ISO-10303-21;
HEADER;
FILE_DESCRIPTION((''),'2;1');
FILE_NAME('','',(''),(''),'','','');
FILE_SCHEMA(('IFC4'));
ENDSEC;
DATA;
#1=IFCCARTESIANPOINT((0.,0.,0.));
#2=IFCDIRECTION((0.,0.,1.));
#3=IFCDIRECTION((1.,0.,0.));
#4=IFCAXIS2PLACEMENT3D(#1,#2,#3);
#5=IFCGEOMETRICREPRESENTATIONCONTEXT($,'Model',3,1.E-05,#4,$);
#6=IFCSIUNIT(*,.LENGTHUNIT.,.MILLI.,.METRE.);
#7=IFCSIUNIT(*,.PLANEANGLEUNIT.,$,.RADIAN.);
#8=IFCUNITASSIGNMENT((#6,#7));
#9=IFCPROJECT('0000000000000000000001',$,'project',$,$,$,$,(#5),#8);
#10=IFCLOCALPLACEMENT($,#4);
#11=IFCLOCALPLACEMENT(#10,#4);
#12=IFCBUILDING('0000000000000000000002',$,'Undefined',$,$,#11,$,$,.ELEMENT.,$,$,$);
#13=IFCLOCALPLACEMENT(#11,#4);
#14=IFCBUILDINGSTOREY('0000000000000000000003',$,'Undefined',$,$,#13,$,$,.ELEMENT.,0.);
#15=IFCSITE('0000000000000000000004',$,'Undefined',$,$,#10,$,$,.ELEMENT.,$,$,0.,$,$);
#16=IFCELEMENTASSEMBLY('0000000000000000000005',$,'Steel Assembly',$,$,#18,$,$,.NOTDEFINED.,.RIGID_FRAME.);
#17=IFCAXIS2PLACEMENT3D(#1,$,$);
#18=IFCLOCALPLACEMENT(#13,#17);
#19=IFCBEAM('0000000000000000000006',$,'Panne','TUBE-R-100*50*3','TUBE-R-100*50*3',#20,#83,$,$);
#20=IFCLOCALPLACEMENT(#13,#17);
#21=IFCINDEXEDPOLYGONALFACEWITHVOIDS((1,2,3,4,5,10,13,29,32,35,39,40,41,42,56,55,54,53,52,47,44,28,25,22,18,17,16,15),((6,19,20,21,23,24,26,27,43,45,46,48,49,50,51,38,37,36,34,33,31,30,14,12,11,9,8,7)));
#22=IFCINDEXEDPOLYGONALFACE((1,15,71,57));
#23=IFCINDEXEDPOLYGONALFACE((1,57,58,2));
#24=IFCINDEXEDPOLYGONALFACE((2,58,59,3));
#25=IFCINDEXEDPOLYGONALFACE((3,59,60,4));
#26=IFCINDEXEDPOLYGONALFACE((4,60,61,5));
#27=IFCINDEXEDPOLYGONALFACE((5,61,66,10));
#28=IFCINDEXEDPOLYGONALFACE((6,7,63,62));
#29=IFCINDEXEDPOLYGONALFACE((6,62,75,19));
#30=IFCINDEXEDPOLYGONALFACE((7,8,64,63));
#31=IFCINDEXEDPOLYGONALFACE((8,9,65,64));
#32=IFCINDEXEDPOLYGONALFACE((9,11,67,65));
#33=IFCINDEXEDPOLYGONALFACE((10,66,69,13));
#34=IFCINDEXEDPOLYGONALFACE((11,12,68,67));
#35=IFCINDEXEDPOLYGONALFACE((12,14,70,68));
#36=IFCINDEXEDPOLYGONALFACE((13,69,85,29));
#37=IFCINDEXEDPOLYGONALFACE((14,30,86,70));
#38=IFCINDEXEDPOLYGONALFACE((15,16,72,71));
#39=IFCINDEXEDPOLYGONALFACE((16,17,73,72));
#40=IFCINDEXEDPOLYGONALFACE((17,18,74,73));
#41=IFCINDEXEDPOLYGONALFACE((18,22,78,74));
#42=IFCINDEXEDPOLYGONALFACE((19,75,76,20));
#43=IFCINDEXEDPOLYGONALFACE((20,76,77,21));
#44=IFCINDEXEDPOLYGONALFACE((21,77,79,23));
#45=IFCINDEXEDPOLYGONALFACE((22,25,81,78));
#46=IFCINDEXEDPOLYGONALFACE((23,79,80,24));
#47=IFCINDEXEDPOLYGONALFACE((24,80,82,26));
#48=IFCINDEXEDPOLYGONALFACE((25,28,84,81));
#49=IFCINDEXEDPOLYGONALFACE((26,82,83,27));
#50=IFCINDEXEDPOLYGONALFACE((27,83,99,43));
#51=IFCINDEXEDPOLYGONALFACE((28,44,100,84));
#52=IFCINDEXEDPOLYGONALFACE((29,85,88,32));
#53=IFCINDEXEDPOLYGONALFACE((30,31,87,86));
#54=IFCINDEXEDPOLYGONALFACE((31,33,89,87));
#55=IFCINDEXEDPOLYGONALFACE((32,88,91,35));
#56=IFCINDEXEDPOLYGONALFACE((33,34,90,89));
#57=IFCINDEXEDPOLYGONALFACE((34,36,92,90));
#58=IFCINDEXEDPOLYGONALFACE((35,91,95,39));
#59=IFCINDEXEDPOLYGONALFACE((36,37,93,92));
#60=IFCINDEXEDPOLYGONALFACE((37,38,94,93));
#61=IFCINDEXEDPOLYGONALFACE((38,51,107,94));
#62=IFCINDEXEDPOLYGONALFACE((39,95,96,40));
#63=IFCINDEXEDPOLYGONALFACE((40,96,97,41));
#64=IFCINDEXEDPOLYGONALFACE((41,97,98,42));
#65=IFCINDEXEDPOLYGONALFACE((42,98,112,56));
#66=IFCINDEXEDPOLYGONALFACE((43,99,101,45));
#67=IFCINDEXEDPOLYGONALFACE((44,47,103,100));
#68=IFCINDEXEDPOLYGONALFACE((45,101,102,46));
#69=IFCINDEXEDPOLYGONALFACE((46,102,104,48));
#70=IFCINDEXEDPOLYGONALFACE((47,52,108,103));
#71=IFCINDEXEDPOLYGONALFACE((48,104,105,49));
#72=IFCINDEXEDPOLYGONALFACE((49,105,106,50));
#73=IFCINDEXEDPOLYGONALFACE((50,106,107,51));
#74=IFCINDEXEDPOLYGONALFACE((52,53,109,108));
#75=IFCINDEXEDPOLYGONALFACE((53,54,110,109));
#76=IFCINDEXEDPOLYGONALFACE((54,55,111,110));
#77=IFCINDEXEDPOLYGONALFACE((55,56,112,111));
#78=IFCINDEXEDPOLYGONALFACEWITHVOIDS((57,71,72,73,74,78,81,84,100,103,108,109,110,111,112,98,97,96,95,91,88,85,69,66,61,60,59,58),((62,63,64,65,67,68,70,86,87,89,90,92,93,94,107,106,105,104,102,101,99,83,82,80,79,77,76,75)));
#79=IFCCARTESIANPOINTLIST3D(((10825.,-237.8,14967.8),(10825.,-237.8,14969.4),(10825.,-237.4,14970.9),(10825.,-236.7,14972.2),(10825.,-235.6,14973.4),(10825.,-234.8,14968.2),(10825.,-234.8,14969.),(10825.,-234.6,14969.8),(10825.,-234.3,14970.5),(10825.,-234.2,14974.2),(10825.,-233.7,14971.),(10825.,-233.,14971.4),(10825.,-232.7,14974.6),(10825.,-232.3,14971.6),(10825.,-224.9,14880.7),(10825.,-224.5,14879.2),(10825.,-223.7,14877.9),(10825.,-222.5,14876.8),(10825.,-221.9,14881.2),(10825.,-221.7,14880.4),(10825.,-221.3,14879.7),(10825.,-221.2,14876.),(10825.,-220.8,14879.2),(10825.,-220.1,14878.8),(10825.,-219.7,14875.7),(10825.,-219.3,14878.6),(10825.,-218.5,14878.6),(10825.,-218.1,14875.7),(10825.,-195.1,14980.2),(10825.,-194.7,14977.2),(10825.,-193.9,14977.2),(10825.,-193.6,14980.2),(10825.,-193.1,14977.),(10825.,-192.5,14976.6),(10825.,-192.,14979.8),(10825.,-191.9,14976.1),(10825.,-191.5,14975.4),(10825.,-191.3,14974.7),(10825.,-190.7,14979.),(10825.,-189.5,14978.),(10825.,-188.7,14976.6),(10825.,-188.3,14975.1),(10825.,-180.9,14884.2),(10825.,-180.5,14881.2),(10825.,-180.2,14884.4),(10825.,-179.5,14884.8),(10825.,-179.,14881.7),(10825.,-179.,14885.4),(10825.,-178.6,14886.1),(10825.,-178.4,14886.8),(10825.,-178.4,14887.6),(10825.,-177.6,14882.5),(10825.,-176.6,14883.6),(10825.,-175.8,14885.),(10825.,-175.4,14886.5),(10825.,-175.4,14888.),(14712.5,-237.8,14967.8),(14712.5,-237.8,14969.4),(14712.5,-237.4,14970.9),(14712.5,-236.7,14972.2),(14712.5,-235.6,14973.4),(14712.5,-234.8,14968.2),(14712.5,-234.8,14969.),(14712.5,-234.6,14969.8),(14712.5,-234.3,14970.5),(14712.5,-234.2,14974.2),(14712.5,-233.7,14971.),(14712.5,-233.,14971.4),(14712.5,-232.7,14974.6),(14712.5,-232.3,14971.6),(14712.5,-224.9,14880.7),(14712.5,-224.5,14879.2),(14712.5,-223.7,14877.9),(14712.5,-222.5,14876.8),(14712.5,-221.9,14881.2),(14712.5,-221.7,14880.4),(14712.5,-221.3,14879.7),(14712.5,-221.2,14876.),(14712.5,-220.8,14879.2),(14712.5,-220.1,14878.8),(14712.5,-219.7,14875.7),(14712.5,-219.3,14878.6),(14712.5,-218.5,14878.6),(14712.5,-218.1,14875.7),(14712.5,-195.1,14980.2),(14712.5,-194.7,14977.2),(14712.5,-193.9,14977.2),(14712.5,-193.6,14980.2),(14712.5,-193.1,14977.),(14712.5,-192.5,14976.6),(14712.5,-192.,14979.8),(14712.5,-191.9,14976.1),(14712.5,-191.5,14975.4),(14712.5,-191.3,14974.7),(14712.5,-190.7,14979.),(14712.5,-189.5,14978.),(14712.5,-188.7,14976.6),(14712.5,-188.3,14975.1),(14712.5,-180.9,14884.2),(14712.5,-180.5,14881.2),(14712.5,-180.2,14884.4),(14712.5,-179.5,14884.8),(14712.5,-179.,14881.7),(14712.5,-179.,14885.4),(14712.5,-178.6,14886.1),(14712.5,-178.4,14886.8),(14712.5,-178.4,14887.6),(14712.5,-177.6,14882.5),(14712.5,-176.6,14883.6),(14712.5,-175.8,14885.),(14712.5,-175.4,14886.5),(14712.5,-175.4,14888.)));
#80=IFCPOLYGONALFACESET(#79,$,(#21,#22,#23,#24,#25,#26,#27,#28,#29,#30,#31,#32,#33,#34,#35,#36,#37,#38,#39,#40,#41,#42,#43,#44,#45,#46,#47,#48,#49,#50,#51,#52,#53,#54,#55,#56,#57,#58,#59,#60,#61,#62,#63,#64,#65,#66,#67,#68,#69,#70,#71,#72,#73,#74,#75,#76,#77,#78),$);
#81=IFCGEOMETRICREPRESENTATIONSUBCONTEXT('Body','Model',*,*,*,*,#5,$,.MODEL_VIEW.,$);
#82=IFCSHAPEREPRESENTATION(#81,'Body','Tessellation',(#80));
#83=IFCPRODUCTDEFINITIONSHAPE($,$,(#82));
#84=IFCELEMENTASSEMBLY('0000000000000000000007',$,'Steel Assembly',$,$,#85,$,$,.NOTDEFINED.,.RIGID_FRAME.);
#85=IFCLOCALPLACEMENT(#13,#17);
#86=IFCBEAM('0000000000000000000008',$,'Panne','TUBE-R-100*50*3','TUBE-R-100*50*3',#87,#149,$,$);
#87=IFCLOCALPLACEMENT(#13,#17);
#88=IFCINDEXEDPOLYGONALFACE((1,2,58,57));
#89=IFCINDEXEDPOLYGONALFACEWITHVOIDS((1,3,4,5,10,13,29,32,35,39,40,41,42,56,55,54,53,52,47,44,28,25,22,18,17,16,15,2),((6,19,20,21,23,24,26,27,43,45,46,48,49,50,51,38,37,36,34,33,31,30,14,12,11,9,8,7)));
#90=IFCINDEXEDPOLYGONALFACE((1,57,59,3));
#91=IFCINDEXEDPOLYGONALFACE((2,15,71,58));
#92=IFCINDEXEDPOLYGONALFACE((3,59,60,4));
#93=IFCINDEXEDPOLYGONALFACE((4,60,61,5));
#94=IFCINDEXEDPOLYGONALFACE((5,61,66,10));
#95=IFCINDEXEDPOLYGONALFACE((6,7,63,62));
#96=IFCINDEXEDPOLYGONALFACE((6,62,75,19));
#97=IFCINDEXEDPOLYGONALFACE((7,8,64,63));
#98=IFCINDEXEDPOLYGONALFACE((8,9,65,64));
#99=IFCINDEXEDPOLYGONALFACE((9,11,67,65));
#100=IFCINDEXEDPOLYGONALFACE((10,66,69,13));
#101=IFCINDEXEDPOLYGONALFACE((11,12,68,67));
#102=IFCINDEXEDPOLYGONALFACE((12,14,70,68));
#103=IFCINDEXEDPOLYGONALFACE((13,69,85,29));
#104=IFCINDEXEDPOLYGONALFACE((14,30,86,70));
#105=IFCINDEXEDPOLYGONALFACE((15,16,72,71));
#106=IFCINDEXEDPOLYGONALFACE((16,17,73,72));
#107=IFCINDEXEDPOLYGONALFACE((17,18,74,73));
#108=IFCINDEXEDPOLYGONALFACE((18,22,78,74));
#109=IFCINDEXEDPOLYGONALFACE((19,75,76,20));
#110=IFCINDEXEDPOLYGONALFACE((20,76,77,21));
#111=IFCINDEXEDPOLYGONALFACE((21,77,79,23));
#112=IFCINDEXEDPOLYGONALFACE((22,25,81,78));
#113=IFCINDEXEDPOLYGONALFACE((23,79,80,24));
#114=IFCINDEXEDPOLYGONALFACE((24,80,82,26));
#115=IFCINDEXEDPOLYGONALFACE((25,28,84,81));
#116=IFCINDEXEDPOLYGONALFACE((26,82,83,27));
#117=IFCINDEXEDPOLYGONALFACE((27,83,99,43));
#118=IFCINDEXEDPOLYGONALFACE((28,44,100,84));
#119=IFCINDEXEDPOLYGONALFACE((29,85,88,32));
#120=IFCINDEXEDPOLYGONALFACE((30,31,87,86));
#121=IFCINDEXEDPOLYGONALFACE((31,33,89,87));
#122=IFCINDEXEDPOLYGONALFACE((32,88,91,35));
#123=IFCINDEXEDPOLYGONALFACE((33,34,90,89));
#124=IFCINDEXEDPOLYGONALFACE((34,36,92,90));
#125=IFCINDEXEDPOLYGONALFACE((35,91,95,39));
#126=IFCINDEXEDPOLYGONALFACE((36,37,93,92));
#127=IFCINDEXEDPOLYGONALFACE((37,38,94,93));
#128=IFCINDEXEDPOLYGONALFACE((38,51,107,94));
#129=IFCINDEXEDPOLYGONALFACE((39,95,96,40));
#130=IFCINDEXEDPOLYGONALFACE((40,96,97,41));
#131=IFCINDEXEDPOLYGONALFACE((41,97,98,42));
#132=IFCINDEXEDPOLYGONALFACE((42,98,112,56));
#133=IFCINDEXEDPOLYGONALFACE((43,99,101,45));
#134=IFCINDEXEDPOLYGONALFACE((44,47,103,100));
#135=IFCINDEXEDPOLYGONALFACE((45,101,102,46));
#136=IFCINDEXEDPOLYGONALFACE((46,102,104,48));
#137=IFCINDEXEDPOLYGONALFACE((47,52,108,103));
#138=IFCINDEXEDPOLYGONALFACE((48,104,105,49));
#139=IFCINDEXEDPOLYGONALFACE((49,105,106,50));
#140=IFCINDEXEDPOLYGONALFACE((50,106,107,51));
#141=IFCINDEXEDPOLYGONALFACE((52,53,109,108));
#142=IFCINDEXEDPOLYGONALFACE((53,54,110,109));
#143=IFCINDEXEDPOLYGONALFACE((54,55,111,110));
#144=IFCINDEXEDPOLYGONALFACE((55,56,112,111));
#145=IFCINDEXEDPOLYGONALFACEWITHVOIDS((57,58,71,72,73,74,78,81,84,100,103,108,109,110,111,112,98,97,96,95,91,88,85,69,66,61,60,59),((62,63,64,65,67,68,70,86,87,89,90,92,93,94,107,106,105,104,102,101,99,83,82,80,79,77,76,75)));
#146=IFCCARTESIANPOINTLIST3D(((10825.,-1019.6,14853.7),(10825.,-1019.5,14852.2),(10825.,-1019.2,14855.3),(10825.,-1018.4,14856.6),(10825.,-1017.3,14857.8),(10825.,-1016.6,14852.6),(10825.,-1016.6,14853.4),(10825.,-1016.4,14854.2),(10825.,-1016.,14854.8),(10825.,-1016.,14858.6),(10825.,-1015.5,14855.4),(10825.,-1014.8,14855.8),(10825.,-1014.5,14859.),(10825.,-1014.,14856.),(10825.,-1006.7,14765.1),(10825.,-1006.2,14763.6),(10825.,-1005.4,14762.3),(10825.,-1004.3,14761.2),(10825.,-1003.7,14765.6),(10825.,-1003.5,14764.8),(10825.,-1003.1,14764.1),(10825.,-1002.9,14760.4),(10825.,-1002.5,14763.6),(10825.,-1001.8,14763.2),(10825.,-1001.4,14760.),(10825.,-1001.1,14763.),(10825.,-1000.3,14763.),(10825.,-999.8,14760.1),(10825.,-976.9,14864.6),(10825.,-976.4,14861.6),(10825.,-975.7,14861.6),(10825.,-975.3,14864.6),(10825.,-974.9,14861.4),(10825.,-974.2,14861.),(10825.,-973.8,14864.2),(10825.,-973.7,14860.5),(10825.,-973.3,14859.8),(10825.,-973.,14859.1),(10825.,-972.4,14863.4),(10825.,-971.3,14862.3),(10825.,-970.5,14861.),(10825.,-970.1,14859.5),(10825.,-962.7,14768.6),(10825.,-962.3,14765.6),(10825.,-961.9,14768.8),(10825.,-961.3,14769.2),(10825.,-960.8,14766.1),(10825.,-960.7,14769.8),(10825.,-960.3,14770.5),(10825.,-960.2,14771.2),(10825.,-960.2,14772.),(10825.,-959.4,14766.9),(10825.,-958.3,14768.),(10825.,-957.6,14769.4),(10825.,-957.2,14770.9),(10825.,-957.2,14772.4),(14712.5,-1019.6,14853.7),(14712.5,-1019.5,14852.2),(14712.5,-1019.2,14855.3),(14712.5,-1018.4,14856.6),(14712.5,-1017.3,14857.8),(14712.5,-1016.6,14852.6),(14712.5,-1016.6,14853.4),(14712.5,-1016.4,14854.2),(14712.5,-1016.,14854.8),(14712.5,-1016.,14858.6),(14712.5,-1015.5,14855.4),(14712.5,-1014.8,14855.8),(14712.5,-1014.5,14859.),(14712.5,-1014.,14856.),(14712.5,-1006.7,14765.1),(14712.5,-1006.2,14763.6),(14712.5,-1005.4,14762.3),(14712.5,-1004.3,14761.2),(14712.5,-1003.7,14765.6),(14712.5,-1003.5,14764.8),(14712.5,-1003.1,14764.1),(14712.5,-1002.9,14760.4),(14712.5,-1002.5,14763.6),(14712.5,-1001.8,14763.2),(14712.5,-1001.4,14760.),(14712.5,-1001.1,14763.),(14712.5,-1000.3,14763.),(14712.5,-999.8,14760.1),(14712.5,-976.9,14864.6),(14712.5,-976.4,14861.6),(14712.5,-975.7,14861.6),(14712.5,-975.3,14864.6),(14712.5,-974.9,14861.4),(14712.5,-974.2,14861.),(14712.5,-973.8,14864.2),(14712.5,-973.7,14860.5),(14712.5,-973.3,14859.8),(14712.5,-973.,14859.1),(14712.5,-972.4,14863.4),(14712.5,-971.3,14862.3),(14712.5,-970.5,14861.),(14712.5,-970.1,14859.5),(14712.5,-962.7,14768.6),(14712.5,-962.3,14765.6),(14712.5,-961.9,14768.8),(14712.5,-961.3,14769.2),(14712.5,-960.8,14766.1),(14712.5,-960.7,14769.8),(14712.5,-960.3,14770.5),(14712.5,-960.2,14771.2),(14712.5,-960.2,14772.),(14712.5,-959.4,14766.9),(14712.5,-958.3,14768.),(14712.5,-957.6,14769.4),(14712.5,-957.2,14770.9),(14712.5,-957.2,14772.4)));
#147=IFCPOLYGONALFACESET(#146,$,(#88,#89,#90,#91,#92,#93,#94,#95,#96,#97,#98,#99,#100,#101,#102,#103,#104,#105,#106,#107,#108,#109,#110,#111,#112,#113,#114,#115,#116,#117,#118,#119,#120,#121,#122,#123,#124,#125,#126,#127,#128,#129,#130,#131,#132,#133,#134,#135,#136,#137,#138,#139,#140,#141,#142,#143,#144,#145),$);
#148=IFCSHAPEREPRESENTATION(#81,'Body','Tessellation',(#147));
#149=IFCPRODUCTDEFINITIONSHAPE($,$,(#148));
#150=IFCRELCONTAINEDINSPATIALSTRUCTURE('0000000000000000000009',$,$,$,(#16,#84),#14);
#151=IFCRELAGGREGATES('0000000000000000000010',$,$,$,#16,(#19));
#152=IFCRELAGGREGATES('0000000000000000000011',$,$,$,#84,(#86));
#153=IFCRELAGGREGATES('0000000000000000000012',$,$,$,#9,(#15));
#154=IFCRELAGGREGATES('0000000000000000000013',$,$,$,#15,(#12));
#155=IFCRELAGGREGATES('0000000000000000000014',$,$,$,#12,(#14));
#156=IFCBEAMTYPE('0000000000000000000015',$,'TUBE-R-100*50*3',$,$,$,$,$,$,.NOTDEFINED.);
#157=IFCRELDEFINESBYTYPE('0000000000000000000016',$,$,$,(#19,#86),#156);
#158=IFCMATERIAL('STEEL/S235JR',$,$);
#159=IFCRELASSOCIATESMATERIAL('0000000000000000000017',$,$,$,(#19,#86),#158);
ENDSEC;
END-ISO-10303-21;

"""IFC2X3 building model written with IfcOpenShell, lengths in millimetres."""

from ifc_helpers import new_model, si_unit, frame, origin_with_axes, origin_2d_with_axis, place, context, subcontext, project, spatial, hollow_rectangle, extrude, material, type_object, element, aggregate, save


model = new_model("IFC2X3")

# Units and contexts
model_context = context("Model", 3, precision=1e-05, world=origin_with_axes())
body_context = subcontext(model_context, "Body", "Model", "MODEL_VIEW")
ifc_project = project(units=[si_unit("LENGTHUNIT", "METRE", prefix="MILLI"), si_unit("PLANEANGLEUNIT", "RADIAN")], contexts=[model_context])

# Site, building, storey
site_placement = place(None, origin_with_axes())
site = spatial("IfcSite", under=ifc_project, at=site_placement, Name="Undefined", CompositionType="ELEMENT", RefElevation=0.0)
building_placement = place(site_placement, origin_with_axes())
building = spatial("IfcBuilding", under=site, at=building_placement, Name="Undefined", CompositionType="ELEMENT")
storey_placement = place(building_placement, origin_with_axes())
storey = spatial("IfcBuildingStorey", under=building, at=storey_placement, Name="Undefined", CompositionType="ELEMENT", Elevation=0.0)

# Element assemblies, beams
ifc_material_1 = material(Name="STEEL/S235JR")
assembly_1_placement = place(storey_placement, origin_with_axes())
assembly_1 = element("IfcElementAssembly", 1, at=assembly_1_placement, inside=storey, Name="Steel Assembly", AssemblyPlace="NOTDEFINED", PredefinedType="RIGID_FRAME")
beam_type_1 = type_object("IfcBeamType", Name="TUBE-R-100*50*3", PredefinedType="NOTDEFINED")
beam_1_placement = place(assembly_1_placement, frame((14712.5, -206.6, 14927.9), z_axis=(0.0, 0.146286, -0.989242), x_axis=(-1.0, 0.0, 0.0)))
beam_1 = element("IfcBeam", 2, at=beam_1_placement, type_object=beam_type_1, material=ifc_material_1, Name="Panne", Description="TUBE-R-100*50*3", ObjectType="TUBE-R-100*50*3", context=body_context, shape_type="SweptSolid", body=[
    extrude(hollow_rectangle(XDim=50.0, YDim=100.0, WallThickness=3.0, InnerFilletRadius=3.0, OuterFilletRadius=6.0, at=origin_2d_with_axis()), frame((3887.5, 0.0, 0.0), z_axis=(-1.0, 0.0, 0.0), x_axis=(0.0, -1.0, 0.0)), (0.0, 0.0, 1.0), 3887.5),
])
aggregate(assembly_1, [beam_1])
assembly_2_placement = place(storey_placement, origin_with_axes())
assembly_2 = element("IfcElementAssembly", 3, at=assembly_2_placement, inside=storey, Name="Steel Assembly", AssemblyPlace="NOTDEFINED", PredefinedType="RIGID_FRAME")
beam_2_placement = place(assembly_2_placement, frame((14712.5, -988.4, 14812.3), z_axis=(0.0, 0.146286, -0.989242), x_axis=(-1.0, 0.0, 0.0)))
beam_2 = element("IfcBeam", 4, at=beam_2_placement, type_object=beam_type_1, material=ifc_material_1, Name="Panne", Description="TUBE-R-100*50*3", ObjectType="TUBE-R-100*50*3", context=body_context, shape_type="SweptSolid", body=[
    extrude(hollow_rectangle(XDim=50.0, YDim=100.0, WallThickness=3.0, InnerFilletRadius=3.0, OuterFilletRadius=6.0, at=origin_2d_with_axis()), frame((3887.5, 0.0, 0.0), z_axis=(-1.0, 0.0, 0.0), x_axis=(0.0, -1.0, 0.0)), (0.0, 0.0, 1.0), 3887.5),
])
aggregate(assembly_2, [beam_2])

save(model, "model.ifc")
